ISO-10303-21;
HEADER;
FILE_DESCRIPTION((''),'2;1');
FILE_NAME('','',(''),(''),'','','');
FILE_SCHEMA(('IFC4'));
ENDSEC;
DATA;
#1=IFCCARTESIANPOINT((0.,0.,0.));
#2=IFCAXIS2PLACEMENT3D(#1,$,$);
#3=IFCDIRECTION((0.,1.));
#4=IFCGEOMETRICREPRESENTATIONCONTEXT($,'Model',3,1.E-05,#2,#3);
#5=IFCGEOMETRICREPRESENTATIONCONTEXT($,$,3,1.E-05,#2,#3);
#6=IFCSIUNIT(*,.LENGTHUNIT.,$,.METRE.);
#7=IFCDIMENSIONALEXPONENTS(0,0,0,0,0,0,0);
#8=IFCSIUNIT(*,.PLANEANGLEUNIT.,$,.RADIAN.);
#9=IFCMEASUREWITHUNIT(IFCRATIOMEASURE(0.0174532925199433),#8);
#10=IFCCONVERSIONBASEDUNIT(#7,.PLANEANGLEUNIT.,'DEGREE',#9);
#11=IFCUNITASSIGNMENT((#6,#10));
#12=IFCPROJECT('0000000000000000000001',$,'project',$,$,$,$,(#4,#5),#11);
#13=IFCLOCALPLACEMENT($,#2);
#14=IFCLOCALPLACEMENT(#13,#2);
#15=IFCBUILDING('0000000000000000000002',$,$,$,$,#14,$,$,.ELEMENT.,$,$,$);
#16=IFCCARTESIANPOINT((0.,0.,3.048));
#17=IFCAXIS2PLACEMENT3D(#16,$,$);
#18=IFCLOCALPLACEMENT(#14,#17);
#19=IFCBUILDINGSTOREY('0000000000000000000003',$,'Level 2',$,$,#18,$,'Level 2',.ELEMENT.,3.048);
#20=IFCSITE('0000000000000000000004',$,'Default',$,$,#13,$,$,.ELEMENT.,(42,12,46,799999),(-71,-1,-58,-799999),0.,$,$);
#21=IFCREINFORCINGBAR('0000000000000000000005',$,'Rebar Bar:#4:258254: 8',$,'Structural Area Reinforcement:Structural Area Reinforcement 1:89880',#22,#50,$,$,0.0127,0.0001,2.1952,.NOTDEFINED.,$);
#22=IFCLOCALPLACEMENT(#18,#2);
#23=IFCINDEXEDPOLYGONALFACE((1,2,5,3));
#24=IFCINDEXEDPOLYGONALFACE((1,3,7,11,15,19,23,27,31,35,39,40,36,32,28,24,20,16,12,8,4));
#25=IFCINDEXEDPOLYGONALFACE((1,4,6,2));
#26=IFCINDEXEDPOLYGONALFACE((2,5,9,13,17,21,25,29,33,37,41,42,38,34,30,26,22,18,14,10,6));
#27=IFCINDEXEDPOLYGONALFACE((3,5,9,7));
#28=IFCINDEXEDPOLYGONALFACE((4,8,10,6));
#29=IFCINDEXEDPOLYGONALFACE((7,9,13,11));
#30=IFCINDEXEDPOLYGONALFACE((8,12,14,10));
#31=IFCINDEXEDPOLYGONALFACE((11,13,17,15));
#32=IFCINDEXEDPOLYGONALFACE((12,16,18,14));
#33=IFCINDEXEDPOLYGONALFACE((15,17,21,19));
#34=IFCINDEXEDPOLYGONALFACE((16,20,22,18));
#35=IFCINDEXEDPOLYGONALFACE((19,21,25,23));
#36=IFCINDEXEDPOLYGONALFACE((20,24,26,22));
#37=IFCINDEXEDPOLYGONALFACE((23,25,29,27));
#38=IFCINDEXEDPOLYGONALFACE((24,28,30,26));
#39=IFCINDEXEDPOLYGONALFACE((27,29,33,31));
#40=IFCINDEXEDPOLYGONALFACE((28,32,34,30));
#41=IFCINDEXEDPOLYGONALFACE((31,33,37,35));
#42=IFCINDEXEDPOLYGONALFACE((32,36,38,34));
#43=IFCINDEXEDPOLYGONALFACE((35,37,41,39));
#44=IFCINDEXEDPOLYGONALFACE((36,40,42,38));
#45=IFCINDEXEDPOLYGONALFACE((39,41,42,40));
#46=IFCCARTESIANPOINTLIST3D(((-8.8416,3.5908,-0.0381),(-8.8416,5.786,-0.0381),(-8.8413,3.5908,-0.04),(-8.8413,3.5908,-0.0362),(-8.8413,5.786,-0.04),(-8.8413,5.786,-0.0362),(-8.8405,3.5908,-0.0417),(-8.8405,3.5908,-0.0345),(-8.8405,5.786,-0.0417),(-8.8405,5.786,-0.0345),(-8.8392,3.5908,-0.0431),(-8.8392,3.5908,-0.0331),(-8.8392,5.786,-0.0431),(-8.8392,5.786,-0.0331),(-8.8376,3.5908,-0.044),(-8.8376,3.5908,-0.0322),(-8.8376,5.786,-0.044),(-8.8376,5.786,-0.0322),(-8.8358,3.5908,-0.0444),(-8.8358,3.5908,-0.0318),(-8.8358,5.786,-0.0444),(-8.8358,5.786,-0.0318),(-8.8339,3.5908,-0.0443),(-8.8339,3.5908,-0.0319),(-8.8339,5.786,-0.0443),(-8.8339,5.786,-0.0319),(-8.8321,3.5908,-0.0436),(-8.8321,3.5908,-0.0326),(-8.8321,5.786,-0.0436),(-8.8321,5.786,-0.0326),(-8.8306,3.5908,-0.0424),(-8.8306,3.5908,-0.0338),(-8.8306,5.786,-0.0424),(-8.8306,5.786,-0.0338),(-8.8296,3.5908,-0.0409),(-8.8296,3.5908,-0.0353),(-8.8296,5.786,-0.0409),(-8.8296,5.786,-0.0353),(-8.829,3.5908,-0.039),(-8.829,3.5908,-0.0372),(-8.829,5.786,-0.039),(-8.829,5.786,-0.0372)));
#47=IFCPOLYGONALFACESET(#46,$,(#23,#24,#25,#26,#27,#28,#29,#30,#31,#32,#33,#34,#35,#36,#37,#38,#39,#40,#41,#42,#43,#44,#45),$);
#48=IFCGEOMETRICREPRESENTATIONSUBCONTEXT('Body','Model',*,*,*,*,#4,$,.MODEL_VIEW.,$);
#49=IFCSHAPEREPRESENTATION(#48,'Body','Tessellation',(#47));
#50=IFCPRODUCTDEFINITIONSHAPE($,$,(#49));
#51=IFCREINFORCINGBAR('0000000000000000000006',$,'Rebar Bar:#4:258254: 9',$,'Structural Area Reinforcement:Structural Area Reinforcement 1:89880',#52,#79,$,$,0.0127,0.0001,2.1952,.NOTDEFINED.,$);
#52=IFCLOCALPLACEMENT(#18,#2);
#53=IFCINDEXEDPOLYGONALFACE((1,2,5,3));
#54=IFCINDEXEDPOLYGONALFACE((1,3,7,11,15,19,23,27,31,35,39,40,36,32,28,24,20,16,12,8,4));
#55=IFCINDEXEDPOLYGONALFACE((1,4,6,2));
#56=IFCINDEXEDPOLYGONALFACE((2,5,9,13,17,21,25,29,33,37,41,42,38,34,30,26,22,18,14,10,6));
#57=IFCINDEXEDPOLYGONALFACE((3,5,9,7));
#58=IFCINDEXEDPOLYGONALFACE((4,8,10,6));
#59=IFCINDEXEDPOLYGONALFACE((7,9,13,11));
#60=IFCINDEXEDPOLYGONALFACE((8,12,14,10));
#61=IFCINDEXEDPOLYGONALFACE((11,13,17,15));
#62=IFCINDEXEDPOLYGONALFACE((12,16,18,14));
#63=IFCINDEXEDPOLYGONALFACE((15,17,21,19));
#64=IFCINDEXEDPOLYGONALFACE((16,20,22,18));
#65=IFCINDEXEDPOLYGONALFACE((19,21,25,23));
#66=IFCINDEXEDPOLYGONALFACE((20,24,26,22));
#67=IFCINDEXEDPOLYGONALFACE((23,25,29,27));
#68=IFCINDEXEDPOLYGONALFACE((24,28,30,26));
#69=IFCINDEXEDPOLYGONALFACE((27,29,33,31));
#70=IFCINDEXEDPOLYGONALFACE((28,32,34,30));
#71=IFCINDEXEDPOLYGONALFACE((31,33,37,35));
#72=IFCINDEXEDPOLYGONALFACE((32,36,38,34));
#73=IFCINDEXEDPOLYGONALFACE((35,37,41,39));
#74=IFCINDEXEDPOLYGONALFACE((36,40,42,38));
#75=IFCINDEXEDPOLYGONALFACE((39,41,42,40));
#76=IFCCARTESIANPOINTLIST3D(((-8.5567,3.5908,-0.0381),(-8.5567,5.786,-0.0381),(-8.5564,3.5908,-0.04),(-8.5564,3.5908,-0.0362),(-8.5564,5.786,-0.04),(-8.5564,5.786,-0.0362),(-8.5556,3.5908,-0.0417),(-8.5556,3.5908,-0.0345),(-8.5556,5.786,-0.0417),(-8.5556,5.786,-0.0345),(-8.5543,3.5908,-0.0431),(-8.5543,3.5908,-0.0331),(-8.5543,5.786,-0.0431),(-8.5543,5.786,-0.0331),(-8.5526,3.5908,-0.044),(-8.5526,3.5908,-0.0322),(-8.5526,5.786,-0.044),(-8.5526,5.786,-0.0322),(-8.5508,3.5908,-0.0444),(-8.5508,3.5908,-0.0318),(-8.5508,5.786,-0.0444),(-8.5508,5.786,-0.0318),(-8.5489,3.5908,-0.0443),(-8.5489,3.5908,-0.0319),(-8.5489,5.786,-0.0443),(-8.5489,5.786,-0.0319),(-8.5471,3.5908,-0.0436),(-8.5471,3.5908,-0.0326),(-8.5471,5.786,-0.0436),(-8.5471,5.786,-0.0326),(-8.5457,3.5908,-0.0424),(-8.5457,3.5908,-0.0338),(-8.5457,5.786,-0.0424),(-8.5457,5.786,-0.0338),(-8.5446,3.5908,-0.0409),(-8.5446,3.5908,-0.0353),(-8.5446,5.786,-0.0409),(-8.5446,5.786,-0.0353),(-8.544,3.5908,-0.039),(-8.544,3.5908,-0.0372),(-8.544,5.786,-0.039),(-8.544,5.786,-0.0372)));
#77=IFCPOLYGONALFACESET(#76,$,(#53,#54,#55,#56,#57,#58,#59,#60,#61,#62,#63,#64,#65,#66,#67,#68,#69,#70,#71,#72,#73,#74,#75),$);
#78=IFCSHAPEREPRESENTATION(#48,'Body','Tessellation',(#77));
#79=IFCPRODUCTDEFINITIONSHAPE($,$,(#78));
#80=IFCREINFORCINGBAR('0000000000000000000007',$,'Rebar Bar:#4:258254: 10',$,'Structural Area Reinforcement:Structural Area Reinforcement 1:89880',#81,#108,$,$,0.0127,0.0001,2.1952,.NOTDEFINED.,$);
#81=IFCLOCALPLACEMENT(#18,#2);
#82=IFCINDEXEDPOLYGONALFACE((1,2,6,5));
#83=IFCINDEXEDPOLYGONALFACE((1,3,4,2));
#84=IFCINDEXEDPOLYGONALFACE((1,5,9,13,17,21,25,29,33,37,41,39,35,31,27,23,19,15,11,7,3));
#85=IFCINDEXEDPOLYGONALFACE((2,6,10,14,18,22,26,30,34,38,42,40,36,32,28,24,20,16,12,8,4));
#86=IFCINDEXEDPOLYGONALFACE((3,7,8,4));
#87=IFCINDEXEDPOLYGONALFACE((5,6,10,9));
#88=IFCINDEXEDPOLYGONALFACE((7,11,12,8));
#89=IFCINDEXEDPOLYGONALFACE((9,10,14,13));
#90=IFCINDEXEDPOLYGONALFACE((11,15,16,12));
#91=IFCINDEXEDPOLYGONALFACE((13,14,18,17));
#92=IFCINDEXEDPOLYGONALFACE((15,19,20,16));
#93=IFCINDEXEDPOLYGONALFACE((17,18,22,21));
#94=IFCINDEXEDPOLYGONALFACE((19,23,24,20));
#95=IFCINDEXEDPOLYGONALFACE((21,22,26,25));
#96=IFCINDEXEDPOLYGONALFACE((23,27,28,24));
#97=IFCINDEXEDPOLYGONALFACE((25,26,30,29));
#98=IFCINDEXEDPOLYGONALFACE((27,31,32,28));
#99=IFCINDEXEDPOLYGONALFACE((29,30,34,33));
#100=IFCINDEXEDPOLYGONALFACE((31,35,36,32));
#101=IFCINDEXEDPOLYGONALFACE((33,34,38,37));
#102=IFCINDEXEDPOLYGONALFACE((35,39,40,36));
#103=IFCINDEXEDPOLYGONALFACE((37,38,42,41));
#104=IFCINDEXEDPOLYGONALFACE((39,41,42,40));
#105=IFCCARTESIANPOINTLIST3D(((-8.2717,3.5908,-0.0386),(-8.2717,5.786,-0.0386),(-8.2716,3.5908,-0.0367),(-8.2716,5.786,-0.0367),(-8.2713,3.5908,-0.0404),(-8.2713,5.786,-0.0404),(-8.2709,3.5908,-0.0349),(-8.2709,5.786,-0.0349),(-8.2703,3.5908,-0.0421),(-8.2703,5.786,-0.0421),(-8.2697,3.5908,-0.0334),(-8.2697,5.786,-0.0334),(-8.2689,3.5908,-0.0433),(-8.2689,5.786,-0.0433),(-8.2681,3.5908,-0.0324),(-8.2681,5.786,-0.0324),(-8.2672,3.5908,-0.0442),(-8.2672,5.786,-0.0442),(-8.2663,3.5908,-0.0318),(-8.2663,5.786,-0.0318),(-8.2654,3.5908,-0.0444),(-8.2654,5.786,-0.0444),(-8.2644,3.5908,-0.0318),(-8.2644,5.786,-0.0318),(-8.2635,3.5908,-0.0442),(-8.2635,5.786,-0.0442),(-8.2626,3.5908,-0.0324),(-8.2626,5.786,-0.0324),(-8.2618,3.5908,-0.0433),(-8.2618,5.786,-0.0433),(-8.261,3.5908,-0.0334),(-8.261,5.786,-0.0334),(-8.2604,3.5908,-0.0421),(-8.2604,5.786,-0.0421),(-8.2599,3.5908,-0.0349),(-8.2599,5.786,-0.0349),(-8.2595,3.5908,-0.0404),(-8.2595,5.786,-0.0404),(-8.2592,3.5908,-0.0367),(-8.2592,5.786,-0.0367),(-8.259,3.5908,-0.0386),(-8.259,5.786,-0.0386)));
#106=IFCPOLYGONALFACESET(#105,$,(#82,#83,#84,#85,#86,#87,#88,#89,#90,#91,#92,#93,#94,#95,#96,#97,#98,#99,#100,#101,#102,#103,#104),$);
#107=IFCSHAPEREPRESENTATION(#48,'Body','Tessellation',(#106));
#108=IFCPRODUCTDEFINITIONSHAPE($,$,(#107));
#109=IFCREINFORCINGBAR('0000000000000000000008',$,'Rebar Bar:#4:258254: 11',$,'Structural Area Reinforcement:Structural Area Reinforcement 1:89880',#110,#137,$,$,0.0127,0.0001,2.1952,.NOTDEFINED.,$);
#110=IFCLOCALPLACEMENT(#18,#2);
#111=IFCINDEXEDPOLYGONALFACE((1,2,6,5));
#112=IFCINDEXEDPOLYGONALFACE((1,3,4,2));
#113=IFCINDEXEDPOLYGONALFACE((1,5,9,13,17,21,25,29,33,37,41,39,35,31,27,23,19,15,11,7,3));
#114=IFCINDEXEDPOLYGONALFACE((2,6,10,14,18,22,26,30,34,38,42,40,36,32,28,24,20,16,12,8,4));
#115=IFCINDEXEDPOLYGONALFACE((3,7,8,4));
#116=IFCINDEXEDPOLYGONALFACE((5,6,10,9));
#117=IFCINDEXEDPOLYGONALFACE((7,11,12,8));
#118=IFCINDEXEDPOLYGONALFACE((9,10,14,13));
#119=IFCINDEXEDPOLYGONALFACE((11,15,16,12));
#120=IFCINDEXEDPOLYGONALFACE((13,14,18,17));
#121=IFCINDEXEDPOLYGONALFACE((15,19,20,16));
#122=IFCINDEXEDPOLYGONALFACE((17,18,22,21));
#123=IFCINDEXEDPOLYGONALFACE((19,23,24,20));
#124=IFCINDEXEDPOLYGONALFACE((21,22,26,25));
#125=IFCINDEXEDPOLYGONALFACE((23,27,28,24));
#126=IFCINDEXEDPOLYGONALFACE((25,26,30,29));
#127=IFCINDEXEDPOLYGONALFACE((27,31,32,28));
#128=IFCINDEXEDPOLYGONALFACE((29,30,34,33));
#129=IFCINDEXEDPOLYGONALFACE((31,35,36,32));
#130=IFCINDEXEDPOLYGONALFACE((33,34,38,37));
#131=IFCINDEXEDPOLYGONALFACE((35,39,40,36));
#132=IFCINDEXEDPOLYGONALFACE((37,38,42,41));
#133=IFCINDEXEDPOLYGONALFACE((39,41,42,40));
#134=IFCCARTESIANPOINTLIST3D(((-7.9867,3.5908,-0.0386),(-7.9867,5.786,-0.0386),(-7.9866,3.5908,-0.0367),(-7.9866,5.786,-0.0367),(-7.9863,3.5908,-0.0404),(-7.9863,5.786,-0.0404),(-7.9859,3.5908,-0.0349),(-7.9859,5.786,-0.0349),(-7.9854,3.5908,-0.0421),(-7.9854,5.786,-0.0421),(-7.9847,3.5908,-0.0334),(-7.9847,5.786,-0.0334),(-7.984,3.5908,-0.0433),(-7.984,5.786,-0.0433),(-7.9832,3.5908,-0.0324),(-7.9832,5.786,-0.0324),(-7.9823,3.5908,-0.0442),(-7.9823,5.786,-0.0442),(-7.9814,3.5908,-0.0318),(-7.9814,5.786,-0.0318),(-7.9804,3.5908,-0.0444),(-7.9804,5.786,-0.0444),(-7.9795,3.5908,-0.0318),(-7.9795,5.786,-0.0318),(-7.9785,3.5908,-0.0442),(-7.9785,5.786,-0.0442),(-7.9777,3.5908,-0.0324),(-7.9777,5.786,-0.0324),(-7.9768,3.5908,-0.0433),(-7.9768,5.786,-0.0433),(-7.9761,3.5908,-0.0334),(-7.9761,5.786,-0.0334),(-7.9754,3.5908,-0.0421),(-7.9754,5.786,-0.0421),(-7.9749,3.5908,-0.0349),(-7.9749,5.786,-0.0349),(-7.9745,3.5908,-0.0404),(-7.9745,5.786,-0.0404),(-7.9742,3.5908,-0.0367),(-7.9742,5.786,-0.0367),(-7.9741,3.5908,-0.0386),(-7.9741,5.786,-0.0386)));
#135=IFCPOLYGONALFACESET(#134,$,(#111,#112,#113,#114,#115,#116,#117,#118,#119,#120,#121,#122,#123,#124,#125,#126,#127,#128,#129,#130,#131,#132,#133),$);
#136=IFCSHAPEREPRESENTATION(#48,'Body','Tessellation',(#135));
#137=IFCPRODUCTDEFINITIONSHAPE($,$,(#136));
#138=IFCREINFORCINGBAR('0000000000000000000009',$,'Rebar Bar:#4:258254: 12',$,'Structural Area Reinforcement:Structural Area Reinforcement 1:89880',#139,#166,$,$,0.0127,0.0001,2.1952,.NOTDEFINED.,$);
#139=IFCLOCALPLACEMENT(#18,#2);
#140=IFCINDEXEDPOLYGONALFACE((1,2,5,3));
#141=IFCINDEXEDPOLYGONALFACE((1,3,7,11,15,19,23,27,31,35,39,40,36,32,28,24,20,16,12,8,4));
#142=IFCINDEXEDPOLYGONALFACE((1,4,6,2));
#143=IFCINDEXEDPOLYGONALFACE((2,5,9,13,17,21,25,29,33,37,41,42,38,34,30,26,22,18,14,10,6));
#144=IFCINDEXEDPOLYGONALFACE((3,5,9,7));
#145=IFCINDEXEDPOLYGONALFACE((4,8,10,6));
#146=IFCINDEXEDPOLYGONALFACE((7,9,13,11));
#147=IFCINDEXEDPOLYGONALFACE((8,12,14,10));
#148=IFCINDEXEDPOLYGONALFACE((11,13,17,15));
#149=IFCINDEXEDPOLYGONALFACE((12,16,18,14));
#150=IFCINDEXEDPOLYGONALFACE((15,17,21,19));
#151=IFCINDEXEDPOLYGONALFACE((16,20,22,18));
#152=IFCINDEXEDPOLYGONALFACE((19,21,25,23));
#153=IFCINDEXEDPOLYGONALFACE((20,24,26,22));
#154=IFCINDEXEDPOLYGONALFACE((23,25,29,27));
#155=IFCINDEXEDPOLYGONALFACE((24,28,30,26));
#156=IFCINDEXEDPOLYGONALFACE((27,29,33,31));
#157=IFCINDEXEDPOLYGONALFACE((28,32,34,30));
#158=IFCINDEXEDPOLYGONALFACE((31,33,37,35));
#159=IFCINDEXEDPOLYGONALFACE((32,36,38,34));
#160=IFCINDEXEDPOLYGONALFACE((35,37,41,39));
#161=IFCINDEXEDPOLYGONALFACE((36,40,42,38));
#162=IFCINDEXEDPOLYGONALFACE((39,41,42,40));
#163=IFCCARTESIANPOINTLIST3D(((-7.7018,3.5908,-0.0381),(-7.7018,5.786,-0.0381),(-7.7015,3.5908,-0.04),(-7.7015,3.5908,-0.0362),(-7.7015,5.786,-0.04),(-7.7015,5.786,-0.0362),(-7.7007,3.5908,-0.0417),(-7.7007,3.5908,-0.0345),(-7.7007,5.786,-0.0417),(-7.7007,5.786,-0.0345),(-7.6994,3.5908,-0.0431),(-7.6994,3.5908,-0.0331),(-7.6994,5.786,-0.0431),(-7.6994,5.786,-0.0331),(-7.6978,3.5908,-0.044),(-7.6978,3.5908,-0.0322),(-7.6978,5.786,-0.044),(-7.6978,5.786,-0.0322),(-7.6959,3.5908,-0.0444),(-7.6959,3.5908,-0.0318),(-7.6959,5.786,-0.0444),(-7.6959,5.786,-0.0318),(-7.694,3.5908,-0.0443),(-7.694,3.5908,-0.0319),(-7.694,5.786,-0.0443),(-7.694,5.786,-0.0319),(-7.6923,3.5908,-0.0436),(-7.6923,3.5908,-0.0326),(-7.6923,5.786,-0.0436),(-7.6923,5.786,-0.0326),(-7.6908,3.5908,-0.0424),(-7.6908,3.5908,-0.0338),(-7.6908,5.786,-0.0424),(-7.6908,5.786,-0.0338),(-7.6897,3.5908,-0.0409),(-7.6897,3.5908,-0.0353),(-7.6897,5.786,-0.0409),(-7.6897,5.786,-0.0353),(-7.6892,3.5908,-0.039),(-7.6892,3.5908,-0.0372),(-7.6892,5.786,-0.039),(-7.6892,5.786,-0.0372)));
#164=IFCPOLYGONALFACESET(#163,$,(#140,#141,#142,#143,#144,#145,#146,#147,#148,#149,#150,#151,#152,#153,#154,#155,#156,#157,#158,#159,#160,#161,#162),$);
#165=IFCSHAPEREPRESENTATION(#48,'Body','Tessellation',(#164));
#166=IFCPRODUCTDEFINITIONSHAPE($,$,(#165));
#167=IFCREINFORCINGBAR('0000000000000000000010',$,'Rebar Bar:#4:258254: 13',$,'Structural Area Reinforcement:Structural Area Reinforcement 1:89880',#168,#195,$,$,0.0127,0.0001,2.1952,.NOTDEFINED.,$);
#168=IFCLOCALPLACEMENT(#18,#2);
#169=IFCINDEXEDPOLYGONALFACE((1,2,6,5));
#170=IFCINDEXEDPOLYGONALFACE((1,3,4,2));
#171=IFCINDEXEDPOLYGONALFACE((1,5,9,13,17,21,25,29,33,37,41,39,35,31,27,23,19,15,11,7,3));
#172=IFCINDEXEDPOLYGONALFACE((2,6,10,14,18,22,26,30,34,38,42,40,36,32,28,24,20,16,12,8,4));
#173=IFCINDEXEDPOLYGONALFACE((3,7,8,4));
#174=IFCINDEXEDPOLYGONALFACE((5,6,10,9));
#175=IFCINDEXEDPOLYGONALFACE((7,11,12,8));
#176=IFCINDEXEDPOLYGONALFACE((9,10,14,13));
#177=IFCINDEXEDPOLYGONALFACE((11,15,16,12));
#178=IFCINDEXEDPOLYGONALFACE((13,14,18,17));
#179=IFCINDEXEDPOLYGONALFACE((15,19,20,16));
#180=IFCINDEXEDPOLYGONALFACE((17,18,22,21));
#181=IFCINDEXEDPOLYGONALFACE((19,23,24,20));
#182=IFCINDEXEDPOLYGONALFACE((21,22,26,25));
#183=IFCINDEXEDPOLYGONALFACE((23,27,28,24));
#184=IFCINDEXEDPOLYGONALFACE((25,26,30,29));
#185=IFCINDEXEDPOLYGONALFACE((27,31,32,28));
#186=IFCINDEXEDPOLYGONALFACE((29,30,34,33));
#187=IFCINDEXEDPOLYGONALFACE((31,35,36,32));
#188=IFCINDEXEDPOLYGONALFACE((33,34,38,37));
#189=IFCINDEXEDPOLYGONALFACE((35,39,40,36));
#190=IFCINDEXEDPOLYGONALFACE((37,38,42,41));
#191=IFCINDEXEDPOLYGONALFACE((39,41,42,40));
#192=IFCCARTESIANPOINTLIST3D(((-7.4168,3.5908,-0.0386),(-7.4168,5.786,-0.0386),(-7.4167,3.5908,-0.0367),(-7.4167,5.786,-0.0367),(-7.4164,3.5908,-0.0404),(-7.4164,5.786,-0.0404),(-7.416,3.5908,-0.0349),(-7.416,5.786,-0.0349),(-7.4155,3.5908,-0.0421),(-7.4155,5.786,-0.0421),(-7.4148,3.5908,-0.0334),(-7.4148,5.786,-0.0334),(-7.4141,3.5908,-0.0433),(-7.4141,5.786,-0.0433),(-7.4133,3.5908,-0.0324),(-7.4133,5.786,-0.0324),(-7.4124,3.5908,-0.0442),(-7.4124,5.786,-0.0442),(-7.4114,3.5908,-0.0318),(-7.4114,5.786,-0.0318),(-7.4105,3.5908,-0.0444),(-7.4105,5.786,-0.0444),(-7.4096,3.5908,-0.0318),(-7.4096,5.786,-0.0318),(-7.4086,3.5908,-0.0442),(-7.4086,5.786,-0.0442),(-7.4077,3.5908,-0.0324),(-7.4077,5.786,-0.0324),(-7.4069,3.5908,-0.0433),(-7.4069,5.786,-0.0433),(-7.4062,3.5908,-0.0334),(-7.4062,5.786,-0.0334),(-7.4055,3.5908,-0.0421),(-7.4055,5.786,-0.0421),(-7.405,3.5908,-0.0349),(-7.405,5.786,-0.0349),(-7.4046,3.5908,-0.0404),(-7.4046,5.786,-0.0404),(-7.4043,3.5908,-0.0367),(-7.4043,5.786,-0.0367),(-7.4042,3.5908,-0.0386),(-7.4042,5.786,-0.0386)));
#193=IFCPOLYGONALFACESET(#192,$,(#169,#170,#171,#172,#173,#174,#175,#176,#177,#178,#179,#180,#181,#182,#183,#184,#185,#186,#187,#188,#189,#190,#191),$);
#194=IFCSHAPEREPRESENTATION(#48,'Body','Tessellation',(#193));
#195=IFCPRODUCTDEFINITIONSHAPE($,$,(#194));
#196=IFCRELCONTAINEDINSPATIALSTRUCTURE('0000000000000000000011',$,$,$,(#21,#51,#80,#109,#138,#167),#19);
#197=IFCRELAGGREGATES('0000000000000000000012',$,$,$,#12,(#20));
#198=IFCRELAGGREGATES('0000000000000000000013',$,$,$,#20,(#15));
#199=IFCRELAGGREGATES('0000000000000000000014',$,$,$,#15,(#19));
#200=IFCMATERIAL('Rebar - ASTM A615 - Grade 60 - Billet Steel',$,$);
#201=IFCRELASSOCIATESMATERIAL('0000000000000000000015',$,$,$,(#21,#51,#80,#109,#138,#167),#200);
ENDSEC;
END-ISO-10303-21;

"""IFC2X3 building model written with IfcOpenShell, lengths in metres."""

from ifc_helpers import new_model, entity, si_unit, converted_unit, direction, frame, origin, place, context, subcontext, project, spatial, material, element, save


model = new_model("IFC2X3")

# Units and contexts
model_context = context("Model", 3, precision=1e-05, world=origin(), true_north=direction((0.0, 1.0)))
context_of_model = context(None, 3, precision=1e-05, world=origin(), true_north=direction((0.0, 1.0)))
body_context = subcontext(model_context, "Body", "Model", "MODEL_VIEW")
ifc_project = project(units=[si_unit("LENGTHUNIT", "METRE"), converted_unit("PLANEANGLEUNIT", "DEGREE", entity("IfcRatioMeasure", 0.0174532925199433), si_unit("PLANEANGLEUNIT", "RADIAN"), dimensions=[0, 0, 0, 0, 0, 0, 0])], contexts=[model_context, context_of_model])

# Site, building, storey
site_placement = place(None, origin())
site = spatial("IfcSite", under=ifc_project, at=site_placement, Name="Default", CompositionType="ELEMENT", RefLatitude=(42, 12, 46, 799999), RefLongitude=(-71, -1, -58, -799999), RefElevation=0.0)
building_placement = place(site_placement, origin())
building = spatial("IfcBuilding", under=site, at=building_placement, CompositionType="ELEMENT")
storey_placement = place(building_placement, frame((0.0, 0.0, 3.048)))
storey = spatial("IfcBuildingStorey", under=building, at=storey_placement, Name="Level 2", LongName="Level 2", CompositionType="ELEMENT", Elevation=3.048)

# Reinforcing bars
ifc_material_1 = material(Name="Rebar - ASTM A615 - Grade 60 - Billet Steel")
reinforcing_bar_1_placement = place(storey_placement, origin())
element("IfcReinforcingBar", 1, at=reinforcing_bar_1_placement, inside=storey, material=ifc_material_1, Name="Rebar Bar:#4:258254: 8", ObjectType="Structural Area Reinforcement:Structural Area Reinforcement 1:89880", BarLength=2.1952, BarRole="NOTDEFINED", CrossSectionArea=0.0001, NominalDiameter=0.0127, context=body_context, shape_type="AdvancedSweptSolid", body=[
    entity("IfcSweptDiskSolid", entity("IfcCompositeCurve", [entity("IfcCompositeCurveSegment", "CONTINUOUS", True, entity("IfcPolyline", [entity("IfcCartesianPoint", [-8.8353, 5.786, -0.0381]), entity("IfcCartesianPoint", [-8.8353, 3.5908, -0.0381])]))], False), 0.0063, None, 0.0, 1.0),
])
reinforcing_bar_2_placement = place(storey_placement, origin())
element("IfcReinforcingBar", 2, at=reinforcing_bar_2_placement, inside=storey, material=ifc_material_1, Name="Rebar Bar:#4:258254: 9", ObjectType="Structural Area Reinforcement:Structural Area Reinforcement 1:89880", BarLength=2.1952, BarRole="NOTDEFINED", CrossSectionArea=0.0001, NominalDiameter=0.0127, context=body_context, shape_type="AdvancedSweptSolid", body=[
    entity("IfcSweptDiskSolid", entity("IfcCompositeCurve", [entity("IfcCompositeCurveSegment", "CONTINUOUS", True, entity("IfcPolyline", [entity("IfcCartesianPoint", [-8.5503, 5.786, -0.0381]), entity("IfcCartesianPoint", [-8.5503, 3.5908, -0.0381])]))], False), 0.0063, None, 0.0, 1.0),
])
reinforcing_bar_3_placement = place(storey_placement, origin())
element("IfcReinforcingBar", 3, at=reinforcing_bar_3_placement, inside=storey, material=ifc_material_1, Name="Rebar Bar:#4:258254: 10", ObjectType="Structural Area Reinforcement:Structural Area Reinforcement 1:89880", BarLength=2.1952, BarRole="NOTDEFINED", CrossSectionArea=0.0001, NominalDiameter=0.0127, context=body_context, shape_type="AdvancedSweptSolid", body=[
    entity("IfcSweptDiskSolid", entity("IfcCompositeCurve", [entity("IfcCompositeCurveSegment", "CONTINUOUS", True, entity("IfcPolyline", [entity("IfcCartesianPoint", [-8.2654, 5.786, -0.0381]), entity("IfcCartesianPoint", [-8.2654, 3.5908, -0.0381])]))], False), 0.0063, None, 0.0, 1.0),
])
reinforcing_bar_4_placement = place(storey_placement, origin())
element("IfcReinforcingBar", 4, at=reinforcing_bar_4_placement, inside=storey, material=ifc_material_1, Name="Rebar Bar:#4:258254: 11", ObjectType="Structural Area Reinforcement:Structural Area Reinforcement 1:89880", BarLength=2.1952, BarRole="NOTDEFINED", CrossSectionArea=0.0001, NominalDiameter=0.0127, context=body_context, shape_type="AdvancedSweptSolid", body=[
    entity("IfcSweptDiskSolid", entity("IfcCompositeCurve", [entity("IfcCompositeCurveSegment", "CONTINUOUS", True, entity("IfcPolyline", [entity("IfcCartesianPoint", [-7.9804, 5.786, -0.0381]), entity("IfcCartesianPoint", [-7.9804, 3.5908, -0.0381])]))], False), 0.0063, None, 0.0, 1.0),
])
reinforcing_bar_5_placement = place(storey_placement, origin())
element("IfcReinforcingBar", 5, at=reinforcing_bar_5_placement, inside=storey, material=ifc_material_1, Name="Rebar Bar:#4:258254: 12", ObjectType="Structural Area Reinforcement:Structural Area Reinforcement 1:89880", BarLength=2.1952, BarRole="NOTDEFINED", CrossSectionArea=0.0001, NominalDiameter=0.0127, context=body_context, shape_type="AdvancedSweptSolid", body=[
    entity("IfcSweptDiskSolid", entity("IfcCompositeCurve", [entity("IfcCompositeCurveSegment", "CONTINUOUS", True, entity("IfcPolyline", [entity("IfcCartesianPoint", [-7.6955, 5.786, -0.0381]), entity("IfcCartesianPoint", [-7.6955, 3.5908, -0.0381])]))], False), 0.0063, None, 0.0, 1.0),
])
reinforcing_bar_6_placement = place(storey_placement, origin())
element("IfcReinforcingBar", 6, at=reinforcing_bar_6_placement, inside=storey, material=ifc_material_1, Name="Rebar Bar:#4:258254: 13", ObjectType="Structural Area Reinforcement:Structural Area Reinforcement 1:89880", BarLength=2.1952, BarRole="NOTDEFINED", CrossSectionArea=0.0001, NominalDiameter=0.0127, context=body_context, shape_type="AdvancedSweptSolid", body=[
    entity("IfcSweptDiskSolid", entity("IfcCompositeCurve", [entity("IfcCompositeCurveSegment", "CONTINUOUS", True, entity("IfcPolyline", [entity("IfcCartesianPoint", [-7.4105, 5.786, -0.0381]), entity("IfcCartesianPoint", [-7.4105, 3.5908, -0.0381])]))], False), 0.0063, None, 0.0, 1.0),
])

save(model, "model.ifc")
